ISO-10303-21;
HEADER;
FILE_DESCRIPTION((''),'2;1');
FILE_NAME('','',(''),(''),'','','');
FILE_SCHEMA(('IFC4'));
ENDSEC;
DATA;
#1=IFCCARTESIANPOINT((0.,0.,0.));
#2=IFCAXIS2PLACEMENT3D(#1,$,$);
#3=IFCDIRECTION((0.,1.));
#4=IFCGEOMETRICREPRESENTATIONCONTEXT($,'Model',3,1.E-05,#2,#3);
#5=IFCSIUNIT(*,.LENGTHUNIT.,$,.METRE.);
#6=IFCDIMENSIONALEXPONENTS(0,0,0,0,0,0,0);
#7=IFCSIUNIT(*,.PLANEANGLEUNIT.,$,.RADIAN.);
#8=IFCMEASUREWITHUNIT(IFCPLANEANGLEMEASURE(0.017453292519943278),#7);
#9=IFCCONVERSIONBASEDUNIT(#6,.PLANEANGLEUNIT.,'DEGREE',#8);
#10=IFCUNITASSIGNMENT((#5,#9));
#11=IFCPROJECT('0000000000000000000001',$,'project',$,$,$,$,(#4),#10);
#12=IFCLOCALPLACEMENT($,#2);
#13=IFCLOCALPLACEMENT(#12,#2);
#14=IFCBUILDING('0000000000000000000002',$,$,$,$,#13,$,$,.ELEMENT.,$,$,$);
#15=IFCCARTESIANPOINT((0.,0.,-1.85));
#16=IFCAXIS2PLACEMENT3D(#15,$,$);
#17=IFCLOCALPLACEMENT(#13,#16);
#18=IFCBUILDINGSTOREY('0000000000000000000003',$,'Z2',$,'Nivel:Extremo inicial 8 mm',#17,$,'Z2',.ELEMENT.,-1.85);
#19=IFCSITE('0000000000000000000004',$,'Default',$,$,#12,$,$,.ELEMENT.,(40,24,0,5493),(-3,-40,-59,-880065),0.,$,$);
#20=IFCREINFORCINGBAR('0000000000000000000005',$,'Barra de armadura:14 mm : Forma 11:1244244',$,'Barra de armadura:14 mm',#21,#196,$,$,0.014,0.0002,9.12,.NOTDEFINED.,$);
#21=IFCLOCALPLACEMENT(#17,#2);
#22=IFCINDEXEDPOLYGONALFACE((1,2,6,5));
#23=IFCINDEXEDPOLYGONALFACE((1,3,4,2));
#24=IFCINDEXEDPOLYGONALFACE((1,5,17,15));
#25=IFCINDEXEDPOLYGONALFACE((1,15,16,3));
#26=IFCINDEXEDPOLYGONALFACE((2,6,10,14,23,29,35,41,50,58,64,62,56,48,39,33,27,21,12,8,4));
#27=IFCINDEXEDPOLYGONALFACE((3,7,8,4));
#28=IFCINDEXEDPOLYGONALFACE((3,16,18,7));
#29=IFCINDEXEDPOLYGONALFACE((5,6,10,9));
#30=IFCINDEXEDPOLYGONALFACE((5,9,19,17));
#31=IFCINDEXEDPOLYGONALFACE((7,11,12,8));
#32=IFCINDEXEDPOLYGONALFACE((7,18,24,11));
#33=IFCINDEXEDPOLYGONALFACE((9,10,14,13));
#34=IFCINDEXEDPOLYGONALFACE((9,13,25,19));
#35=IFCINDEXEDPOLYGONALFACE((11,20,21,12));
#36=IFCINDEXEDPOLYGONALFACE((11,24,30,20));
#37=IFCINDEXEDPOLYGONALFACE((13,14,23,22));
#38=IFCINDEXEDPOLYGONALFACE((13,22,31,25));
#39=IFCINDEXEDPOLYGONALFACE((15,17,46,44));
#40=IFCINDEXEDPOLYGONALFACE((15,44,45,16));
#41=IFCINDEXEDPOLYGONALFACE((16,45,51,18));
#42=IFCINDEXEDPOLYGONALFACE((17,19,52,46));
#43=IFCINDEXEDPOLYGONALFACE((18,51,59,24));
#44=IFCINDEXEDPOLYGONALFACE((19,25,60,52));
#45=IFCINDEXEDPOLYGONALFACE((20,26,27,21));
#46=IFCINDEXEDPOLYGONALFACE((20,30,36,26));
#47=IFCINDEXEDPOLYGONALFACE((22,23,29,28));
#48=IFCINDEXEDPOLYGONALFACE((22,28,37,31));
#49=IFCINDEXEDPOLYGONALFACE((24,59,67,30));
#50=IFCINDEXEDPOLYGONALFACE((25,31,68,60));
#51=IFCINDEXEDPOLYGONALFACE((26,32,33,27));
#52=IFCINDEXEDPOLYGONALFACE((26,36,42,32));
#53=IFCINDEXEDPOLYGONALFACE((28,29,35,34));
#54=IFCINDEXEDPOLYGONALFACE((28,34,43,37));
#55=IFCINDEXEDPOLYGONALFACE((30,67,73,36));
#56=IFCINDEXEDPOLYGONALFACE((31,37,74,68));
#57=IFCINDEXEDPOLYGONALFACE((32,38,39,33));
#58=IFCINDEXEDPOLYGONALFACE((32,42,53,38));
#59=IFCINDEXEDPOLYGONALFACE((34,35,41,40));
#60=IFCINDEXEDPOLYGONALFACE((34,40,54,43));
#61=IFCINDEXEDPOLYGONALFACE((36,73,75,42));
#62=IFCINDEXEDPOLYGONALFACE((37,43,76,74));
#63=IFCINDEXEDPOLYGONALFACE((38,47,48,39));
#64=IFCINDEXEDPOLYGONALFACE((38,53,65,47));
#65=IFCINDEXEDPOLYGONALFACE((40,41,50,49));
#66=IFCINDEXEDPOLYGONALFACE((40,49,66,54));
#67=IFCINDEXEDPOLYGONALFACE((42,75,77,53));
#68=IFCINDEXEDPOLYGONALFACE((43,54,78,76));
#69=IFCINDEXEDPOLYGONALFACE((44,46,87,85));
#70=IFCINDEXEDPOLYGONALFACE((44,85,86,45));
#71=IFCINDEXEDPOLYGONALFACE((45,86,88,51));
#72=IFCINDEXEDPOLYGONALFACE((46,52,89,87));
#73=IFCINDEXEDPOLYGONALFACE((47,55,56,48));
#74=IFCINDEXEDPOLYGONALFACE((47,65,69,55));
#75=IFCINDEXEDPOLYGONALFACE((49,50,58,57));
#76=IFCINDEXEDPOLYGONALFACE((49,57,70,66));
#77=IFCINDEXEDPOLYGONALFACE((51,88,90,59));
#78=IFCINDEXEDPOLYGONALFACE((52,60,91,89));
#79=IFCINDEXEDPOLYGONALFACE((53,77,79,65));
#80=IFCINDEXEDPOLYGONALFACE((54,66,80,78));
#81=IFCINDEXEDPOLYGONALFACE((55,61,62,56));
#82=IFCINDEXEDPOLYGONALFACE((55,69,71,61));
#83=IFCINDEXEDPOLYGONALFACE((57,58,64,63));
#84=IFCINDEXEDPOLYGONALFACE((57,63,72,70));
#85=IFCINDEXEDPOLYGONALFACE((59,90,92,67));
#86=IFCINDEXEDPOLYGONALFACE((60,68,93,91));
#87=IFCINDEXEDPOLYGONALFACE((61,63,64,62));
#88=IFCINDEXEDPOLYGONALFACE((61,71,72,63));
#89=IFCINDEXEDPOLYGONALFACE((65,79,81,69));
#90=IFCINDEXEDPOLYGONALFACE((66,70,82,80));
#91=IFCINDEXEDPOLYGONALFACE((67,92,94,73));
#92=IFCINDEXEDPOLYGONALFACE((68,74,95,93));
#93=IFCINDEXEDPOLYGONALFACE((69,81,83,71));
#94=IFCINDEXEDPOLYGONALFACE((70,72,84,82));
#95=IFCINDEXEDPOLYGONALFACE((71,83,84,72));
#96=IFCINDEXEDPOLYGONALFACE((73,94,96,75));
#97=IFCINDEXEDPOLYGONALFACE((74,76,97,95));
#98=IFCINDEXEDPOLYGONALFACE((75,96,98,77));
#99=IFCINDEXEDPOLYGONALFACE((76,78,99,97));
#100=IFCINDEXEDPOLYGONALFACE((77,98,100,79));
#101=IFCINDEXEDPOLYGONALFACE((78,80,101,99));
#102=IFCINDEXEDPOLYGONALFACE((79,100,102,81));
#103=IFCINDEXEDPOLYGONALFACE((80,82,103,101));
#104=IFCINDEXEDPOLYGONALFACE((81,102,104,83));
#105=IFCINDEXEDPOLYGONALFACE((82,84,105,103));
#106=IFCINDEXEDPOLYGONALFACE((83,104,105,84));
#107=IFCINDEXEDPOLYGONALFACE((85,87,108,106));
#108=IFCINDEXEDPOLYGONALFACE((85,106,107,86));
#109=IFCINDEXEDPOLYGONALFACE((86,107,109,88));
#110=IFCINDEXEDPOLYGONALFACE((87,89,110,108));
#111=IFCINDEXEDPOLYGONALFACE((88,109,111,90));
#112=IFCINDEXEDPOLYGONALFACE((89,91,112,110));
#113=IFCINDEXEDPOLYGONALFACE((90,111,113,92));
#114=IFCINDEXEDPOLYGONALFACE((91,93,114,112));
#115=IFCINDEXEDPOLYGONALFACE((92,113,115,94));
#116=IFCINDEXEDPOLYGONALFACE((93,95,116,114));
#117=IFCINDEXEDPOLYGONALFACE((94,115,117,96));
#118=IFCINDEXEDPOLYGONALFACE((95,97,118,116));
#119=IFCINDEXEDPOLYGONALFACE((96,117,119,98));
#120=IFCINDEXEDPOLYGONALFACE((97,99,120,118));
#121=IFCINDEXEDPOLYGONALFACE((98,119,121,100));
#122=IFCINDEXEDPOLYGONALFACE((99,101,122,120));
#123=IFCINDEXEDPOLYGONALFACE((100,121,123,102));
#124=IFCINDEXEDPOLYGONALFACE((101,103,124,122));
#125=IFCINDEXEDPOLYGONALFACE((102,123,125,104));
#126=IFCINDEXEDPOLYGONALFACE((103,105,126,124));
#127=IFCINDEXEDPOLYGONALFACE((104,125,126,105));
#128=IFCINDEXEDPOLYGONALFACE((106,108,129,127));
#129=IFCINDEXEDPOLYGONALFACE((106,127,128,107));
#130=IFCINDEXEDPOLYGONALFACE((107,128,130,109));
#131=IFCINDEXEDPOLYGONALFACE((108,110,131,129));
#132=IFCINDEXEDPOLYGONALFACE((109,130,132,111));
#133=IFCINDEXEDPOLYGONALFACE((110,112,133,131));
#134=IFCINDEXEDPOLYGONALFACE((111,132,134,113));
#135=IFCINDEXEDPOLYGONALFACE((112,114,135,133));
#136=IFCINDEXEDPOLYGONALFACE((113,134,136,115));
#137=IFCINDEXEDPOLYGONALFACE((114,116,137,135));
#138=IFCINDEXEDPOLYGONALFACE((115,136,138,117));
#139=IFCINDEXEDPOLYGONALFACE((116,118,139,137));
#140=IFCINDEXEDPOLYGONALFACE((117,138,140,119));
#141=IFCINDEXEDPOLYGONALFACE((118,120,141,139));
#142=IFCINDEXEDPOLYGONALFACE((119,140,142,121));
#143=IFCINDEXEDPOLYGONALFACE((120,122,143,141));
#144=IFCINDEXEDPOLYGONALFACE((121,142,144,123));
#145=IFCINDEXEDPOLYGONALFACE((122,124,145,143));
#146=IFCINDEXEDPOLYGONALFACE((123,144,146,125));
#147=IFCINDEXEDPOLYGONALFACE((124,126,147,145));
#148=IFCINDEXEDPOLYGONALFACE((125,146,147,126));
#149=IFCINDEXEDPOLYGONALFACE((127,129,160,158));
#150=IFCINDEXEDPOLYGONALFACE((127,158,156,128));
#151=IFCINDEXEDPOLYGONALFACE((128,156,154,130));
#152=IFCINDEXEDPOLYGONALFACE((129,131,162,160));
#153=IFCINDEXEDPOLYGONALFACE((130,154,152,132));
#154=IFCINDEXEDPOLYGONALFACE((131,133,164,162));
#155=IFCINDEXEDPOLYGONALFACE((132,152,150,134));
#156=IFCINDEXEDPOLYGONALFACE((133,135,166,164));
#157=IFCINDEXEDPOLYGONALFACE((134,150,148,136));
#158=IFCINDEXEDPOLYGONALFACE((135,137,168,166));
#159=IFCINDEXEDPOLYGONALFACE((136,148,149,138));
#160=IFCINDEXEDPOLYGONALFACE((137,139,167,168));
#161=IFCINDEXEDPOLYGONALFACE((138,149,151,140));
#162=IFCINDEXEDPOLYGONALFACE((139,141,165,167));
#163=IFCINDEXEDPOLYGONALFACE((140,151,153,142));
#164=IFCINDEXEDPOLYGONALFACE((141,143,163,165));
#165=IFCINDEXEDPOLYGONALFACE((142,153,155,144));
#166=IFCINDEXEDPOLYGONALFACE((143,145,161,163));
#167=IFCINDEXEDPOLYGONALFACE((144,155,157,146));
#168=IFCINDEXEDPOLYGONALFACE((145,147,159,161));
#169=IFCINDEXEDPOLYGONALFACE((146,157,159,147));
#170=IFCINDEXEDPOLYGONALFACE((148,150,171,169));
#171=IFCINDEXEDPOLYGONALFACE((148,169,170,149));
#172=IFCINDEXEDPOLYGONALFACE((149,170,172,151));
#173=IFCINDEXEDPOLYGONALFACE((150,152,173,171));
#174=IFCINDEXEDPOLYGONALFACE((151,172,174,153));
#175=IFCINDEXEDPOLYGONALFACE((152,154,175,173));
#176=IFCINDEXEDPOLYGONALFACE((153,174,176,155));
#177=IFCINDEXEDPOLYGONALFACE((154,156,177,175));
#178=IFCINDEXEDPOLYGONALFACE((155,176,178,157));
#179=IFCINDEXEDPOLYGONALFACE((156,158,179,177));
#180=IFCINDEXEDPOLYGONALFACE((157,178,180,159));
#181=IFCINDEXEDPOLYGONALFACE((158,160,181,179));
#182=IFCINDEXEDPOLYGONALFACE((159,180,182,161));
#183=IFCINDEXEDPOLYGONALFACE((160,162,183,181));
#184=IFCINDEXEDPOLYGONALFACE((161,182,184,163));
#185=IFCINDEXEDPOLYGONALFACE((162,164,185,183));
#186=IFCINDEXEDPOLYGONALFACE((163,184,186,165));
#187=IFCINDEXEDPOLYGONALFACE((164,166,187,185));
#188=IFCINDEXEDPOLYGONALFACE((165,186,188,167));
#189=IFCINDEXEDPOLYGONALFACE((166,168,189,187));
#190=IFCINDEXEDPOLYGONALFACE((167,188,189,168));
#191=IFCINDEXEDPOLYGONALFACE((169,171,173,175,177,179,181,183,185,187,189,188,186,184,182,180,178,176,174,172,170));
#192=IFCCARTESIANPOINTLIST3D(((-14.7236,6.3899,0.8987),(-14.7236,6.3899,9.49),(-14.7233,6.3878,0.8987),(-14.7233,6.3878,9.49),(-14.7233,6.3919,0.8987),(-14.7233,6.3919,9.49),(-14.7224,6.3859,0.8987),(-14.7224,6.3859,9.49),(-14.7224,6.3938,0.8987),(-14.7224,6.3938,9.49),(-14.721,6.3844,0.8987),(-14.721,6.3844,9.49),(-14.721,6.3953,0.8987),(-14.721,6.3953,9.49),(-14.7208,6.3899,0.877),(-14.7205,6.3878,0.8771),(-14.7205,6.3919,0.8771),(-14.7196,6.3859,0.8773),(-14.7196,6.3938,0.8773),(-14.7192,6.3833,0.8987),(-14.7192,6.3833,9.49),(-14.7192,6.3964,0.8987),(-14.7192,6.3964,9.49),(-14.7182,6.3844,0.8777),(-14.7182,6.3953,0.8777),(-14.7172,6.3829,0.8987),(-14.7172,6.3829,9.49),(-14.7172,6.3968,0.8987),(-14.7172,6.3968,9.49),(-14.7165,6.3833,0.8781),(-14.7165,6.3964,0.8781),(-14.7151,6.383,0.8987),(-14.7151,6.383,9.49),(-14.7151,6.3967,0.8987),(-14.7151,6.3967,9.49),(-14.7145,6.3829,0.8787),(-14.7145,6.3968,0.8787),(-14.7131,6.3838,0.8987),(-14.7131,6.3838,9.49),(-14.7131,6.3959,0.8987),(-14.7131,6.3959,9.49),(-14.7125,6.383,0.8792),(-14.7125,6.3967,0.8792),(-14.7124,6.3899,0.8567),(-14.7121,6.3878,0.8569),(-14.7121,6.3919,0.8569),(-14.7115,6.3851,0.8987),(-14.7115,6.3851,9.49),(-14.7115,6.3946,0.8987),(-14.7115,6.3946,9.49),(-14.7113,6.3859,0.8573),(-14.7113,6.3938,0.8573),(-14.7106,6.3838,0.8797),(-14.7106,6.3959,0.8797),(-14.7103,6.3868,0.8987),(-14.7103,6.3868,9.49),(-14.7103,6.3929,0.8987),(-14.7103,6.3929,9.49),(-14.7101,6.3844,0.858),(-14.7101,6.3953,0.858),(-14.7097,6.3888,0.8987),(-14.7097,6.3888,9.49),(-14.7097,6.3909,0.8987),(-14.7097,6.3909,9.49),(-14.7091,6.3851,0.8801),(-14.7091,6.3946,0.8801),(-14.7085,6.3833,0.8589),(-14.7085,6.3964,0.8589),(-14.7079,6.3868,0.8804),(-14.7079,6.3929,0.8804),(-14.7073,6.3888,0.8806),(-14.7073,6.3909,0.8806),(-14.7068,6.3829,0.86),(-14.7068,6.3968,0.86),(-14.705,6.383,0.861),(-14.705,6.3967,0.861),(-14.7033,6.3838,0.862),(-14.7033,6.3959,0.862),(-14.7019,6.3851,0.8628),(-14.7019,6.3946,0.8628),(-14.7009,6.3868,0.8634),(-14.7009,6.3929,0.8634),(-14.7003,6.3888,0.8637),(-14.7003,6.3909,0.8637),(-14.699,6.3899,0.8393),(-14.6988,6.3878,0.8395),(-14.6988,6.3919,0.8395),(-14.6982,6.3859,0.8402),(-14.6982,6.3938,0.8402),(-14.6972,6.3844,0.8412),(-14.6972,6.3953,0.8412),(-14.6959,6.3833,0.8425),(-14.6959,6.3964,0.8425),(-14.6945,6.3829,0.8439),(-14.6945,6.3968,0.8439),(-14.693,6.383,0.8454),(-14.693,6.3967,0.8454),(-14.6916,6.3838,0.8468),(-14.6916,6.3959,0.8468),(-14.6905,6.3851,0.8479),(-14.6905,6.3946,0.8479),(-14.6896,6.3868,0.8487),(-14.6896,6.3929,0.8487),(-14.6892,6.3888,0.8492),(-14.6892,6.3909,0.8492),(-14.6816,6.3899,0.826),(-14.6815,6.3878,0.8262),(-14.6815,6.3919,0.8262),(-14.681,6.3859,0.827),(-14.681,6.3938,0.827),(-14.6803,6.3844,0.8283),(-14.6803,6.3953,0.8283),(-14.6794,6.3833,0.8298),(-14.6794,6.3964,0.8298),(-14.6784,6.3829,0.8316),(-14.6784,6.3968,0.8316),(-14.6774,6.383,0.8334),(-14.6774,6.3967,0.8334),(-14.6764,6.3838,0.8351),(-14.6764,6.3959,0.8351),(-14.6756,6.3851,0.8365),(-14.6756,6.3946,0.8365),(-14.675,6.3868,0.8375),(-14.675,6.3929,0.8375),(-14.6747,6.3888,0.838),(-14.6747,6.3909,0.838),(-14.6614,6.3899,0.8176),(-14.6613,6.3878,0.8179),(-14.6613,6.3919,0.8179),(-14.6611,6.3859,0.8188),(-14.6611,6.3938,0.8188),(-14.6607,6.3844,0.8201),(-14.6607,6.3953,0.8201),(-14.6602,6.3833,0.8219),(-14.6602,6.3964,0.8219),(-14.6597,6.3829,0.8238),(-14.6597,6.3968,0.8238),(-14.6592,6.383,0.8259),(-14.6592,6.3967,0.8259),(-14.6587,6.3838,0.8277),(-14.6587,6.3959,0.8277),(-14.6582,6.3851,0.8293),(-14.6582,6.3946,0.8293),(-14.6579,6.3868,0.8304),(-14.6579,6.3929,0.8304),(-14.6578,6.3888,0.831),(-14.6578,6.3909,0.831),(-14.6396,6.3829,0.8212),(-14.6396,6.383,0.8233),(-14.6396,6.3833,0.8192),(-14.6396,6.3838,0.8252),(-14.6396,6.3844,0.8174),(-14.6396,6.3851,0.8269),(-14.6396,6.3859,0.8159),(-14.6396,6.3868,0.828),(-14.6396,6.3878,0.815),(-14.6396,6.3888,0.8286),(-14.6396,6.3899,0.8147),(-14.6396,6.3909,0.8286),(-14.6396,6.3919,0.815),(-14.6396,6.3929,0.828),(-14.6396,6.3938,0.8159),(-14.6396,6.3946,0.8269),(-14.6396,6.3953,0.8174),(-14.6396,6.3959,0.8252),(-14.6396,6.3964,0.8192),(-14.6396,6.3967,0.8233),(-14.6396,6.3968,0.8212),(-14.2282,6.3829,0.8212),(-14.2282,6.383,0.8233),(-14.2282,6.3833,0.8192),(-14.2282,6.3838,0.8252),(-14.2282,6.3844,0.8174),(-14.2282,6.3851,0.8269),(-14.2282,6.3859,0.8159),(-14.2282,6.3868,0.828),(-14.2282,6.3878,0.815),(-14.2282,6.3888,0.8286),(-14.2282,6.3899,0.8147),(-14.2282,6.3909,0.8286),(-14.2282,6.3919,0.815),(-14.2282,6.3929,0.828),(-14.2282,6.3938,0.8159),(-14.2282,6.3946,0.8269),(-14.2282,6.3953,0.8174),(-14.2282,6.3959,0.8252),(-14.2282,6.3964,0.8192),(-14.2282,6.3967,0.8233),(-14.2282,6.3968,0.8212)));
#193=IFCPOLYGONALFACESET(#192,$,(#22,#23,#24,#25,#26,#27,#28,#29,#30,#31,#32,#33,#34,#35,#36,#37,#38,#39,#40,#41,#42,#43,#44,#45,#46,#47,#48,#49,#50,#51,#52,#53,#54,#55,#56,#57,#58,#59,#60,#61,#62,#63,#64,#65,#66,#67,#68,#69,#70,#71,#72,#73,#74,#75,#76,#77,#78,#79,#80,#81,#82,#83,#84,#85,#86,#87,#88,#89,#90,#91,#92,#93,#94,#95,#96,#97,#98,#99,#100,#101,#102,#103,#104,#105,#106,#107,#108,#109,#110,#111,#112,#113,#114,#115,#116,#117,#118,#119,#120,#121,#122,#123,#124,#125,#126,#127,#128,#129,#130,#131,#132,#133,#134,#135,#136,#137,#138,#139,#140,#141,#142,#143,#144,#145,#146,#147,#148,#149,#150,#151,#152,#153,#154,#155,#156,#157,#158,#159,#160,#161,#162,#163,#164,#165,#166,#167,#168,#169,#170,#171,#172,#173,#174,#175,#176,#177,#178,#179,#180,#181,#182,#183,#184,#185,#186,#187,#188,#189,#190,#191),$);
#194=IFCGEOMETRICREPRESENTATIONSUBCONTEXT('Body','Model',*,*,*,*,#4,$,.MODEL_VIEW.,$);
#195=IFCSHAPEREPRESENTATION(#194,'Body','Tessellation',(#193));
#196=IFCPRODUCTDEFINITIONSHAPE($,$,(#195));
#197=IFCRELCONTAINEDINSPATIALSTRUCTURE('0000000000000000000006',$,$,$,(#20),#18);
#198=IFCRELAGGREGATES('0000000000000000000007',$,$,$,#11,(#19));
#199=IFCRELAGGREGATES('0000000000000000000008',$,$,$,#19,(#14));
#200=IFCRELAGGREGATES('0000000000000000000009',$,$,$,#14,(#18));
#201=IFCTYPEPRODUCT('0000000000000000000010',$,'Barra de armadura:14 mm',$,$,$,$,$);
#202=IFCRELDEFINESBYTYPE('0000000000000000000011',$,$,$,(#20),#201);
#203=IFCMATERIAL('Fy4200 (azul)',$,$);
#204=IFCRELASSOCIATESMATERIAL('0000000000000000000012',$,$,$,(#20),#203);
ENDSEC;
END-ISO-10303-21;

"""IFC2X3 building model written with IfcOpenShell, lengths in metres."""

from ifc_helpers import new_model, entity, si_unit, converted_unit, direction, frame, origin, place, context, subcontext, project, spatial, material, type_object, element, save


model = new_model("IFC2X3")

# Units and contexts
model_context = context("Model", 3, precision=1e-05, world=origin(), true_north=direction((0.0, 1.0)))
body_context = subcontext(model_context, "Body", "Model", "MODEL_VIEW")
ifc_project = project(units=[si_unit("LENGTHUNIT", "METRE"), converted_unit("PLANEANGLEUNIT", "DEGREE", entity("IfcPlaneAngleMeasure", 0.017453292519943278), si_unit("PLANEANGLEUNIT", "RADIAN"), dimensions=[0, 0, 0, 0, 0, 0, 0])], contexts=[model_context])

# Site, building, storey
site_placement = place(None, origin())
site = spatial("IfcSite", under=ifc_project, at=site_placement, Name="Default", CompositionType="ELEMENT", RefLatitude=(40, 24, 0, 5493), RefLongitude=(-3, -40, -59, -880065), RefElevation=0.0)
building_placement = place(site_placement, origin())
building = spatial("IfcBuilding", under=site, at=building_placement, CompositionType="ELEMENT")
storey_placement = place(building_placement, frame((0.0, 0.0, -1.85)))
storey = spatial("IfcBuildingStorey", under=building, at=storey_placement, Name="Z2", ObjectType="Nivel:Extremo inicial 8 mm", LongName="Z2", CompositionType="ELEMENT", Elevation=-1.85)

# Reinforcing bar
ifc_material_1 = material(Name="Fy4200 (azul)")
type_product_1 = type_object("IfcTypeProduct", Name="Barra de armadura:14 mm")
reinforcing_bar_1_placement = place(storey_placement, origin())
element("IfcReinforcingBar", 1, at=reinforcing_bar_1_placement, inside=storey, type_object=type_product_1, material=ifc_material_1, Name="Barra de armadura:14 mm : Forma 11:1244244", ObjectType="Barra de armadura:14 mm", BarLength=9.12, BarRole="NOTDEFINED", CrossSectionArea=0.0002, NominalDiameter=0.014, context=body_context, shape_type="AdvancedSweptSolid", body=[
    entity("IfcSweptDiskSolid", entity("IfcCompositeCurve", [entity("IfcCompositeCurveSegment", "CONTINUOUS", True, entity("IfcPolyline", [entity("IfcCartesianPoint", [-14.7166, 6.3899, 9.49]), entity("IfcCartesianPoint", [-14.7166, 6.3899, 0.8987])])), entity("IfcCompositeCurveSegment", "CONTINUOUS", True, entity("IfcTrimmedCurve", entity("IfcCircle", entity("IfcAxis2Placement3D", entity("IfcCartesianPoint", [-14.6396, 6.3899, 0.8987]), entity("IfcDirection", [0.0, -1.0, 0.0]), entity("IfcDirection", [0.0, 0.0, -1.0])), 0.077), [entity("IfcParameterValue", 270.0)], [entity("IfcParameterValue", 360.0)], True, "PARAMETER")), entity("IfcCompositeCurveSegment", "CONTINUOUS", True, entity("IfcPolyline", [entity("IfcCartesianPoint", [-14.6396, 6.3899, 0.8217]), entity("IfcCartesianPoint", [-14.2282, 6.3899, 0.8217])]))], False), 0.007, None, 0.0, 92.0),
])

save(model, "model.ifc")
